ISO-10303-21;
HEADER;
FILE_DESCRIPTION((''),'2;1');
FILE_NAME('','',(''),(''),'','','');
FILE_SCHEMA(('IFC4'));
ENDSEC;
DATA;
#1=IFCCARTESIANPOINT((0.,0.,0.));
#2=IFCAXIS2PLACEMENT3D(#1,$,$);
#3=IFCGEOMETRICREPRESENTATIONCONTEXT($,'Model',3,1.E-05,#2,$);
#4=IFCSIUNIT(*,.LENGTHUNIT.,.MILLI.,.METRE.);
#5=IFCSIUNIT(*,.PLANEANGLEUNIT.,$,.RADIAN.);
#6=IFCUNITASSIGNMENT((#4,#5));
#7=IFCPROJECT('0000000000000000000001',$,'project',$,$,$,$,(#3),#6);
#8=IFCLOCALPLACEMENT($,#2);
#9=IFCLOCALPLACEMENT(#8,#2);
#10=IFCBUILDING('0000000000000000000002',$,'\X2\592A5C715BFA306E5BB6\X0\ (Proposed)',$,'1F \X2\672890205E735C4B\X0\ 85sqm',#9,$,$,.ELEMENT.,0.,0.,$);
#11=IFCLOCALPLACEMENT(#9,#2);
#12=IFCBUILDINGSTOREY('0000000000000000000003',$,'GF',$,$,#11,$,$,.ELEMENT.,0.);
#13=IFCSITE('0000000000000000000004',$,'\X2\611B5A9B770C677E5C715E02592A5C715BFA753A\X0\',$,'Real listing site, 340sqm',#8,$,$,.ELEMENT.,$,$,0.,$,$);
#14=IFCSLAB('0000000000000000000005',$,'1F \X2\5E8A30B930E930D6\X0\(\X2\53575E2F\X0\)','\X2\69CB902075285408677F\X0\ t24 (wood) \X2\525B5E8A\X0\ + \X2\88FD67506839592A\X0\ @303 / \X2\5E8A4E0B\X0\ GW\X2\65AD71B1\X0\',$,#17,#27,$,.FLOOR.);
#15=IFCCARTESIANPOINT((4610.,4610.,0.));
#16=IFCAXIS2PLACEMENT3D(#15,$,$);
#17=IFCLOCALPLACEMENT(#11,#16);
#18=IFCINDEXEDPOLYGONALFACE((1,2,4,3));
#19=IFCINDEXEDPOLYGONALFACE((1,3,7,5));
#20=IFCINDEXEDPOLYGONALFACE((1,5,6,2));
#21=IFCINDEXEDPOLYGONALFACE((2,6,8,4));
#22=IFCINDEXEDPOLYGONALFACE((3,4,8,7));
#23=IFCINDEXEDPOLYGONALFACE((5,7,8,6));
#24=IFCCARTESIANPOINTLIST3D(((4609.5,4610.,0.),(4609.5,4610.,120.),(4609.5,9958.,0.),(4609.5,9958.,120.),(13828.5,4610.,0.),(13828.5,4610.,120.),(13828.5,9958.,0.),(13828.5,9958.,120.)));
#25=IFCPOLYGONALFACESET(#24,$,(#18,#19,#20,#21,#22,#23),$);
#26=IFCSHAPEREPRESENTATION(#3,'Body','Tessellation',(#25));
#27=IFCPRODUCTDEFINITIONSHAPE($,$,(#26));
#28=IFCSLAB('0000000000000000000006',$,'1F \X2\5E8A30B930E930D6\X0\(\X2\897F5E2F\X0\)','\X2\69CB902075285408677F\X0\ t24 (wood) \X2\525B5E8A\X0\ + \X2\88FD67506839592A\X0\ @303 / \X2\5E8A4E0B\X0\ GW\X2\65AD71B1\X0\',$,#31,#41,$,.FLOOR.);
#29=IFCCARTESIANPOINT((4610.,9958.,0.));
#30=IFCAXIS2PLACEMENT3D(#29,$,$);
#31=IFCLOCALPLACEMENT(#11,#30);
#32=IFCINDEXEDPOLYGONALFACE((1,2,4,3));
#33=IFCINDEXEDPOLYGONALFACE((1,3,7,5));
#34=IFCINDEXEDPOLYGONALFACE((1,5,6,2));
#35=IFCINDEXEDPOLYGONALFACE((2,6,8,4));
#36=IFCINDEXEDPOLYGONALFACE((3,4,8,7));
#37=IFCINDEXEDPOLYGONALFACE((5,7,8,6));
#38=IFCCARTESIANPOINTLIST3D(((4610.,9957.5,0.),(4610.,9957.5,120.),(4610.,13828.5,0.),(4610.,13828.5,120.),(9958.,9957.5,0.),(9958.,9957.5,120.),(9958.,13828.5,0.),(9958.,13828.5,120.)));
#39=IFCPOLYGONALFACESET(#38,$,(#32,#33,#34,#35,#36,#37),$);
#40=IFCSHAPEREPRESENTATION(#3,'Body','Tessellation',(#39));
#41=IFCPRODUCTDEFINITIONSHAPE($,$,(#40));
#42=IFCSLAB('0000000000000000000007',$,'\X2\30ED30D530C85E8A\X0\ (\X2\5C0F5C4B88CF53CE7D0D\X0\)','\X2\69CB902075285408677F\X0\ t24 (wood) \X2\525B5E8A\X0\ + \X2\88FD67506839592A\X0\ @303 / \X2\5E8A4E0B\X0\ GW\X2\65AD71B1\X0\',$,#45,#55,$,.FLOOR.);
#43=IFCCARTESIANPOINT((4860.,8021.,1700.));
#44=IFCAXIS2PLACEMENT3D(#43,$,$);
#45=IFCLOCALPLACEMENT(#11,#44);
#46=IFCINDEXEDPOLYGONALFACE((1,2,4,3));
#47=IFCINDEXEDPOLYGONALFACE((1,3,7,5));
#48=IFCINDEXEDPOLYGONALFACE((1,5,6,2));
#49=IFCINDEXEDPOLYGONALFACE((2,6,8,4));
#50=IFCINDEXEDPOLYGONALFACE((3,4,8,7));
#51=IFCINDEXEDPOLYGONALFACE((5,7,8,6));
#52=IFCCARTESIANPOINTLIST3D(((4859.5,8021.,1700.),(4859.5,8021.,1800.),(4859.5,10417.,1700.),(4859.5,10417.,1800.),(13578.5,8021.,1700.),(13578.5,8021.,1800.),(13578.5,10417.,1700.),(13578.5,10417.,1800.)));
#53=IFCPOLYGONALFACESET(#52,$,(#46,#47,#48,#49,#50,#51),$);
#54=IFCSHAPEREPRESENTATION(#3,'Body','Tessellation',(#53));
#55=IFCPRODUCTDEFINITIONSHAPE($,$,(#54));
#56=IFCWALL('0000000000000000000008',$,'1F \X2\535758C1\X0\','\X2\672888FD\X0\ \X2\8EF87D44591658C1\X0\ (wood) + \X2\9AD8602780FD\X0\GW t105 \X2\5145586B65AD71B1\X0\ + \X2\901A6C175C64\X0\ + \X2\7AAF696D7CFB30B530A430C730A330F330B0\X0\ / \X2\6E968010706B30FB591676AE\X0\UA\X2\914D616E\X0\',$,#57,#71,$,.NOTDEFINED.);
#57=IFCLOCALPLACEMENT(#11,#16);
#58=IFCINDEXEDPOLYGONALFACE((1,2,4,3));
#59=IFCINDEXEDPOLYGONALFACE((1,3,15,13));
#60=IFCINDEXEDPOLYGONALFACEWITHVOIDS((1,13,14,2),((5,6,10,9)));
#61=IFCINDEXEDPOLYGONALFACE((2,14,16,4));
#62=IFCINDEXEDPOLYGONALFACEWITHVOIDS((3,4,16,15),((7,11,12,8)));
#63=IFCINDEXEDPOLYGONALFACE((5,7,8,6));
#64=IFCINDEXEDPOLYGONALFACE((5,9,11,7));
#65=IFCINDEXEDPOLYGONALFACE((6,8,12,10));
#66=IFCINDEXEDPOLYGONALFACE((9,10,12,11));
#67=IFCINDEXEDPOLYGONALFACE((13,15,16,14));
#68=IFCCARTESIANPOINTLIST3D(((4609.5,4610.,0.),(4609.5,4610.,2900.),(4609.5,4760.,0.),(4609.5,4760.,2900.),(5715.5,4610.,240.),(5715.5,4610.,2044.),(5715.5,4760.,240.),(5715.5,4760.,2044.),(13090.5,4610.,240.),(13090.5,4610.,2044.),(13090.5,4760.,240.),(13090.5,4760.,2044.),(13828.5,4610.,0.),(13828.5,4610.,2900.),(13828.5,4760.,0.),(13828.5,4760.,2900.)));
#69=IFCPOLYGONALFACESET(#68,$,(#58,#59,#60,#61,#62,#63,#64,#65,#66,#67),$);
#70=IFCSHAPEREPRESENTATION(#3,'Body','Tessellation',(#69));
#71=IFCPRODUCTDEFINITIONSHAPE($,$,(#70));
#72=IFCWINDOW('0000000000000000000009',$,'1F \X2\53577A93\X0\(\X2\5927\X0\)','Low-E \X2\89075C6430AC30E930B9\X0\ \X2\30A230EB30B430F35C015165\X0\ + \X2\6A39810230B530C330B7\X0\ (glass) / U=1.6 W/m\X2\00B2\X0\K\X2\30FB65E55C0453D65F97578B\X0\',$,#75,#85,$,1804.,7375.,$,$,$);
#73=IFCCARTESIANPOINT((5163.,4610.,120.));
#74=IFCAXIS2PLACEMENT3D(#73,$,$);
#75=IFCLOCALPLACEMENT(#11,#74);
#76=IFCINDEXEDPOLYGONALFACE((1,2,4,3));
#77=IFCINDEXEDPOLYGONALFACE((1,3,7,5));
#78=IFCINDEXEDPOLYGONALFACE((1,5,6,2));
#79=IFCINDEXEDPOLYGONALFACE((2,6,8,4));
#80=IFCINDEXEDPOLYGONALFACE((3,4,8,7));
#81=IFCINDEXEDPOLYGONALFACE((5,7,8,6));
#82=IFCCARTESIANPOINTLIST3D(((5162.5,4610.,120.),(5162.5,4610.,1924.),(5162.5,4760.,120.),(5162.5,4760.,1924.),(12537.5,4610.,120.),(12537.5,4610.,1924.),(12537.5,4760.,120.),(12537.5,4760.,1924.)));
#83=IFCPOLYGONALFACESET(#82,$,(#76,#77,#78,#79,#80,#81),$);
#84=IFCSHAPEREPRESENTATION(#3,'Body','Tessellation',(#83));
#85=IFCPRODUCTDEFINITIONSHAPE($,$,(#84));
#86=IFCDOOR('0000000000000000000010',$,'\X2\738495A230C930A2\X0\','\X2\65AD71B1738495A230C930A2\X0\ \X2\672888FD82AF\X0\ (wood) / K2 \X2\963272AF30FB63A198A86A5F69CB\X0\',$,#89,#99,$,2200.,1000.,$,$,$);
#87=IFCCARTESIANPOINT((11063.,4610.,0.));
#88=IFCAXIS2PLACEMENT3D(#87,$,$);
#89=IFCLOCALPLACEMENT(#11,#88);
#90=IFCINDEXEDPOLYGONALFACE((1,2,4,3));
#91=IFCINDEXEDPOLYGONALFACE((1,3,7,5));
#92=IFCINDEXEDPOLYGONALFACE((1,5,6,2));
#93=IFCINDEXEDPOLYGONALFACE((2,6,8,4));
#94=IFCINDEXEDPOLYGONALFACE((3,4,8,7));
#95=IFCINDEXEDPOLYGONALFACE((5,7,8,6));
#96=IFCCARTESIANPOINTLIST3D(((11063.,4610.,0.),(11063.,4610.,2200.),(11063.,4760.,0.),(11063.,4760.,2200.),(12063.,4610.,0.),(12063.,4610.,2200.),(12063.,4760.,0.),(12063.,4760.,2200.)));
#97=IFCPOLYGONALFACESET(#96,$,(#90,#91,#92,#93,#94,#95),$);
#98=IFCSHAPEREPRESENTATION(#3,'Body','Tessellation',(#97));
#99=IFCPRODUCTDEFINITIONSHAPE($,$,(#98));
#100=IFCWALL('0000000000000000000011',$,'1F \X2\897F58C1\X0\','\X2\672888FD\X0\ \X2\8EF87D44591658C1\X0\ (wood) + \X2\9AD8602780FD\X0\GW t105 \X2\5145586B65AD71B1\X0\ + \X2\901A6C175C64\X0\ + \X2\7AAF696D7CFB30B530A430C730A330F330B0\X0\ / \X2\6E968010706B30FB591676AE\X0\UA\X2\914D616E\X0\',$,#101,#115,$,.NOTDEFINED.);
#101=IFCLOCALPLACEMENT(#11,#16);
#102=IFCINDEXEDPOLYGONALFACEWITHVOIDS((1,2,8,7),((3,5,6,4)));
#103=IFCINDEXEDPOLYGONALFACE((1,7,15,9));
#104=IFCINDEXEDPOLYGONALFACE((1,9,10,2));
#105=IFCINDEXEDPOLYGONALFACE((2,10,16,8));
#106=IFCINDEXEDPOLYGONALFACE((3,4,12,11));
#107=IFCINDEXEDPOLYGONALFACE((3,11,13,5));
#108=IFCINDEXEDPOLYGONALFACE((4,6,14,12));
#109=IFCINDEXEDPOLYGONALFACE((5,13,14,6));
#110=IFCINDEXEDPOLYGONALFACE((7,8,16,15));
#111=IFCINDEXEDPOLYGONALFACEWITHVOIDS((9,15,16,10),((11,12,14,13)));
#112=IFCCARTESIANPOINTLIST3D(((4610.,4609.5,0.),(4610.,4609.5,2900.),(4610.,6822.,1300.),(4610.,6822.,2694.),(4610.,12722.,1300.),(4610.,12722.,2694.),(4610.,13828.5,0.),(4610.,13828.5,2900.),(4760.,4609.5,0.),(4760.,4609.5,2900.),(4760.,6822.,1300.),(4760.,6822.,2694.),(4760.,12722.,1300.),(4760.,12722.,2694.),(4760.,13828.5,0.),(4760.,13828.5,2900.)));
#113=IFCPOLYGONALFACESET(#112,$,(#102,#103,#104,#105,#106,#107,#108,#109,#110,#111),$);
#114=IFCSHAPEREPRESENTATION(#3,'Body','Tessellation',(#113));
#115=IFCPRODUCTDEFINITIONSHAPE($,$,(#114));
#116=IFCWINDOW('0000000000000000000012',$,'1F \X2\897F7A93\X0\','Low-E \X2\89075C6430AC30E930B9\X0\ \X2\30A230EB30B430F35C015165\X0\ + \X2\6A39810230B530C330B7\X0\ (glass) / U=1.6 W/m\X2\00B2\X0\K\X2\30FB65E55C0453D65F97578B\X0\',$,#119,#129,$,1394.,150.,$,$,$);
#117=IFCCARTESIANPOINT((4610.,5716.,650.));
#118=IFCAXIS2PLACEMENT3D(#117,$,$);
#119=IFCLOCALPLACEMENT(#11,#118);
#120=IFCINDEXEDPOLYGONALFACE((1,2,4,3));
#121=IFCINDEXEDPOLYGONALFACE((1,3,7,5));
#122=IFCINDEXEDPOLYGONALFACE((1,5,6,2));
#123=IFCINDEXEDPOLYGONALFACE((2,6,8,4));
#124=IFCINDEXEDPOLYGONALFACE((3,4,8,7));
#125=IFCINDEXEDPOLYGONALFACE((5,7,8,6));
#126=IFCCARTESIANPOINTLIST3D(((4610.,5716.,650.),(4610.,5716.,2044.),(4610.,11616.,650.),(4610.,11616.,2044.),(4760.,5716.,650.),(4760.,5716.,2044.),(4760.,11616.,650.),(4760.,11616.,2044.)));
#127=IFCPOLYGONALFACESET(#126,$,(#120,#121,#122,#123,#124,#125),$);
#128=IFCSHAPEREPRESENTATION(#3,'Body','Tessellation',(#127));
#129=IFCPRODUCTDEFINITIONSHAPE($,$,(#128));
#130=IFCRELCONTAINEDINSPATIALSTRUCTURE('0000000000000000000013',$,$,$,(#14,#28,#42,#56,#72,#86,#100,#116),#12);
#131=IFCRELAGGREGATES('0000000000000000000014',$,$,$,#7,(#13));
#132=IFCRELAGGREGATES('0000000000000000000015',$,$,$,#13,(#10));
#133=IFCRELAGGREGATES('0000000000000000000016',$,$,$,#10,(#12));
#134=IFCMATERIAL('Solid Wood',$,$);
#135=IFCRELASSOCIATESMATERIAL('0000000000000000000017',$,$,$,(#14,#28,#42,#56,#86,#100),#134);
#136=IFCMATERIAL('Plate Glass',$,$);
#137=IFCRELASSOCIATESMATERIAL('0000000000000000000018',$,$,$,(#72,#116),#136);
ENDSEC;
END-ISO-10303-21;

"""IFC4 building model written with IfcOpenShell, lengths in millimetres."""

from ifc_helpers import new_model, si_unit, frame, frame_2d, origin, place, context, project, spatial, rectangle, extrude, material, element, fill, save


model = new_model("IFC4")

# Units and contexts
model_context = context("Model", 3, precision=1e-05, world=origin())
ifc_project = project(units=[si_unit("LENGTHUNIT", "METRE", prefix="MILLI"), si_unit("PLANEANGLEUNIT", "RADIAN")], contexts=[model_context])

# Site, building, storey
site_placement = place(None, origin())
site = spatial("IfcSite", under=ifc_project, at=site_placement, Name="愛媛県松山市太山寺町", ObjectType="Real listing site, 340sqm", CompositionType="ELEMENT", RefElevation=0.0)
building_placement = place(site_placement, origin())
building = spatial("IfcBuilding", under=site, at=building_placement, Name="太山寺の家 (Proposed)", ObjectType="1F 木造平屋 85sqm", CompositionType="ELEMENT", ElevationOfRefHeight=0.0, ElevationOfTerrain=0.0)
storey_placement = place(building_placement, origin())
storey = spatial("IfcBuildingStorey", under=building, at=storey_placement, Name="GF", CompositionType="ELEMENT", Elevation=0.0)

# Slabs
ifc_material_1 = material(Name="Solid Wood")
slab_1_placement = place(storey_placement, frame((4610.0, 4610.0, 0.0)))
element("IfcSlab", 1, at=slab_1_placement, inside=storey, material=ifc_material_1, Name="1F 床スラブ(南帯)", Description="構造用合板 t24 (wood) 剛床 + 製材根太 @303 / 床下 GW断熱", PredefinedType="FLOOR", context=model_context, shape_type="SweptSolid", body=[
    extrude(rectangle(XDim=9219.0, YDim=5348.0, at=frame_2d((4609.0, 2674.0))), frame((4610.0, 4610.0, 0.0)), (0.0, 0.0, 1.0), 120.0),
])
slab_2_placement = place(storey_placement, frame((4610.0, 9958.0, 0.0)))
element("IfcSlab", 2, at=slab_2_placement, inside=storey, material=ifc_material_1, Name="1F 床スラブ(西帯)", Description="構造用合板 t24 (wood) 剛床 + 製材根太 @303 / 床下 GW断熱", PredefinedType="FLOOR", context=model_context, shape_type="SweptSolid", body=[
    extrude(rectangle(XDim=5348.0, YDim=3871.0, at=frame_2d((2674.0, 1935.0))), frame((4610.0, 9958.0, 0.0)), (0.0, 0.0, 1.0), 120.0),
])
slab_3_placement = place(storey_placement, frame((4860.0, 8021.0, 1700.0)))
element("IfcSlab", 3, at=slab_3_placement, inside=storey, material=ifc_material_1, Name="ロフト床 (小屋裏収納)", Description="構造用合板 t24 (wood) 剛床 + 製材根太 @303 / 床下 GW断熱", PredefinedType="FLOOR", context=model_context, shape_type="SweptSolid", body=[
    extrude(rectangle(XDim=8719.0, YDim=2396.0, at=frame_2d((4359.0, 1198.0))), frame((4860.0, 8021.0, 1700.0)), (0.0, 0.0, 1.0), 100.0),
])

# Wall, openings, window, door
wall_1_placement = place(storey_placement, frame((4610.0, 4610.0, 0.0)))
wall_1 = element("IfcWall", 4, at=wall_1_placement, inside=storey, material=ifc_material_1, Name="1F 南壁", Description="木製 軸組外壁 (wood) + 高性能GW t105 充填断熱 + 通気層 + 窯業系サイディング / 準耐火・外皮UA配慮", PredefinedType="NOTDEFINED", context=model_context, shape_type="SweptSolid", body=[
    extrude(rectangle(XDim=9219.0, YDim=150.0, at=frame_2d((4609.0, 75.0))), frame((4610.0, 4610.0, 0.0)), (0.0, 0.0, 1.0), 2900.0),
])
opening_1_placement = place(storey_placement, frame((5163.0, 4610.0, 120.0)))
opening_1 = element("IfcOpeningElement", 5, at=opening_1_placement, cuts=wall_1, PredefinedType="NOTDEFINED", context=model_context, shape_type="SweptSolid", body=[
    extrude(rectangle(XDim=7375.0, YDim=150.0, at=frame_2d((3687.0, 75.0))), frame((5163.0, 4610.0, 120.0)), (0.0, 0.0, 1.0), 1804.0),
])
opening_2_placement = place(storey_placement, frame((11063.0, 4610.0, 0.0)))
opening_2 = element("IfcOpeningElement", 6, at=opening_2_placement, cuts=wall_1, PredefinedType="NOTDEFINED", context=model_context, shape_type="SweptSolid", body=[
    extrude(rectangle(XDim=1000.0, YDim=150.0, at=frame_2d((500.0, 75.0))), frame((11063.0, 4610.0, 0.0)), (0.0, 0.0, 1.0), 2200.0),
])
ifc_material_2 = material(Name="Plate Glass")
window_1_placement = place(storey_placement, frame((5163.0, 4610.0, 120.0)))
window_1 = element("IfcWindow", 7, at=window_1_placement, inside=storey, material=ifc_material_2, Name="1F 南窓(大)", Description="Low-E 複層ガラス アルゴン封入 + 樹脂サッシ (glass) / U=1.6 W/m²K・日射取得型", OverallHeight=1804.0, OverallWidth=7375.0, context=model_context, shape_type="SweptSolid", body=[
    extrude(rectangle(XDim=7375.0, YDim=150.0, at=frame_2d((3687.0, 75.0))), frame((5163.0, 4610.0, 120.0)), (0.0, 0.0, 1.0), 1804.0),
])
fill(opening_1, window_1)
door_placement = place(storey_placement, frame((11063.0, 4610.0, 0.0)))
door = element("IfcDoor", 8, at=door_placement, inside=storey, material=ifc_material_1, Name="玄関ドア", Description="断熱玄関ドア 木製芯 (wood) / K2 防犯・採風機構", OverallHeight=2200.0, OverallWidth=1000.0, context=model_context, shape_type="SweptSolid", body=[
    extrude(rectangle(XDim=1000.0, YDim=150.0, at=frame_2d((500.0, 75.0))), frame((11063.0, 4610.0, 0.0)), (0.0, 0.0, 1.0), 2200.0),
])
fill(opening_2, door)

# Wall, opening, window
wall_2_placement = place(storey_placement, frame((4610.0, 4610.0, 0.0)))
wall_2 = element("IfcWall", 9, at=wall_2_placement, inside=storey, material=ifc_material_1, Name="1F 西壁", Description="木製 軸組外壁 (wood) + 高性能GW t105 充填断熱 + 通気層 + 窯業系サイディング / 準耐火・外皮UA配慮", PredefinedType="NOTDEFINED", context=model_context, shape_type="SweptSolid", body=[
    extrude(rectangle(XDim=150.0, YDim=9219.0, at=frame_2d((75.0, 4609.0))), frame((4610.0, 4610.0, 0.0)), (0.0, 0.0, 1.0), 2900.0),
])
opening_3_placement = place(storey_placement, frame((4610.0, 5716.0, 650.0)))
opening_3 = element("IfcOpeningElement", 10, at=opening_3_placement, cuts=wall_2, PredefinedType="NOTDEFINED", context=model_context, shape_type="SweptSolid", body=[
    extrude(rectangle(XDim=150.0, YDim=5900.0, at=frame_2d((75.0, 2950.0))), frame((4610.0, 5716.0, 650.0)), (0.0, 0.0, 1.0), 1394.0),
])
window_2_placement = place(storey_placement, frame((4610.0, 5716.0, 650.0)))
window_2 = element("IfcWindow", 11, at=window_2_placement, inside=storey, material=ifc_material_2, Name="1F 西窓", Description="Low-E 複層ガラス アルゴン封入 + 樹脂サッシ (glass) / U=1.6 W/m²K・日射取得型", OverallHeight=1394.0, OverallWidth=150.0, context=model_context, shape_type="SweptSolid", body=[
    extrude(rectangle(XDim=150.0, YDim=5900.0, at=frame_2d((75.0, 2950.0))), frame((4610.0, 5716.0, 650.0)), (0.0, 0.0, 1.0), 1394.0),
])
fill(opening_3, window_2)

save(model, "model.ifc")
